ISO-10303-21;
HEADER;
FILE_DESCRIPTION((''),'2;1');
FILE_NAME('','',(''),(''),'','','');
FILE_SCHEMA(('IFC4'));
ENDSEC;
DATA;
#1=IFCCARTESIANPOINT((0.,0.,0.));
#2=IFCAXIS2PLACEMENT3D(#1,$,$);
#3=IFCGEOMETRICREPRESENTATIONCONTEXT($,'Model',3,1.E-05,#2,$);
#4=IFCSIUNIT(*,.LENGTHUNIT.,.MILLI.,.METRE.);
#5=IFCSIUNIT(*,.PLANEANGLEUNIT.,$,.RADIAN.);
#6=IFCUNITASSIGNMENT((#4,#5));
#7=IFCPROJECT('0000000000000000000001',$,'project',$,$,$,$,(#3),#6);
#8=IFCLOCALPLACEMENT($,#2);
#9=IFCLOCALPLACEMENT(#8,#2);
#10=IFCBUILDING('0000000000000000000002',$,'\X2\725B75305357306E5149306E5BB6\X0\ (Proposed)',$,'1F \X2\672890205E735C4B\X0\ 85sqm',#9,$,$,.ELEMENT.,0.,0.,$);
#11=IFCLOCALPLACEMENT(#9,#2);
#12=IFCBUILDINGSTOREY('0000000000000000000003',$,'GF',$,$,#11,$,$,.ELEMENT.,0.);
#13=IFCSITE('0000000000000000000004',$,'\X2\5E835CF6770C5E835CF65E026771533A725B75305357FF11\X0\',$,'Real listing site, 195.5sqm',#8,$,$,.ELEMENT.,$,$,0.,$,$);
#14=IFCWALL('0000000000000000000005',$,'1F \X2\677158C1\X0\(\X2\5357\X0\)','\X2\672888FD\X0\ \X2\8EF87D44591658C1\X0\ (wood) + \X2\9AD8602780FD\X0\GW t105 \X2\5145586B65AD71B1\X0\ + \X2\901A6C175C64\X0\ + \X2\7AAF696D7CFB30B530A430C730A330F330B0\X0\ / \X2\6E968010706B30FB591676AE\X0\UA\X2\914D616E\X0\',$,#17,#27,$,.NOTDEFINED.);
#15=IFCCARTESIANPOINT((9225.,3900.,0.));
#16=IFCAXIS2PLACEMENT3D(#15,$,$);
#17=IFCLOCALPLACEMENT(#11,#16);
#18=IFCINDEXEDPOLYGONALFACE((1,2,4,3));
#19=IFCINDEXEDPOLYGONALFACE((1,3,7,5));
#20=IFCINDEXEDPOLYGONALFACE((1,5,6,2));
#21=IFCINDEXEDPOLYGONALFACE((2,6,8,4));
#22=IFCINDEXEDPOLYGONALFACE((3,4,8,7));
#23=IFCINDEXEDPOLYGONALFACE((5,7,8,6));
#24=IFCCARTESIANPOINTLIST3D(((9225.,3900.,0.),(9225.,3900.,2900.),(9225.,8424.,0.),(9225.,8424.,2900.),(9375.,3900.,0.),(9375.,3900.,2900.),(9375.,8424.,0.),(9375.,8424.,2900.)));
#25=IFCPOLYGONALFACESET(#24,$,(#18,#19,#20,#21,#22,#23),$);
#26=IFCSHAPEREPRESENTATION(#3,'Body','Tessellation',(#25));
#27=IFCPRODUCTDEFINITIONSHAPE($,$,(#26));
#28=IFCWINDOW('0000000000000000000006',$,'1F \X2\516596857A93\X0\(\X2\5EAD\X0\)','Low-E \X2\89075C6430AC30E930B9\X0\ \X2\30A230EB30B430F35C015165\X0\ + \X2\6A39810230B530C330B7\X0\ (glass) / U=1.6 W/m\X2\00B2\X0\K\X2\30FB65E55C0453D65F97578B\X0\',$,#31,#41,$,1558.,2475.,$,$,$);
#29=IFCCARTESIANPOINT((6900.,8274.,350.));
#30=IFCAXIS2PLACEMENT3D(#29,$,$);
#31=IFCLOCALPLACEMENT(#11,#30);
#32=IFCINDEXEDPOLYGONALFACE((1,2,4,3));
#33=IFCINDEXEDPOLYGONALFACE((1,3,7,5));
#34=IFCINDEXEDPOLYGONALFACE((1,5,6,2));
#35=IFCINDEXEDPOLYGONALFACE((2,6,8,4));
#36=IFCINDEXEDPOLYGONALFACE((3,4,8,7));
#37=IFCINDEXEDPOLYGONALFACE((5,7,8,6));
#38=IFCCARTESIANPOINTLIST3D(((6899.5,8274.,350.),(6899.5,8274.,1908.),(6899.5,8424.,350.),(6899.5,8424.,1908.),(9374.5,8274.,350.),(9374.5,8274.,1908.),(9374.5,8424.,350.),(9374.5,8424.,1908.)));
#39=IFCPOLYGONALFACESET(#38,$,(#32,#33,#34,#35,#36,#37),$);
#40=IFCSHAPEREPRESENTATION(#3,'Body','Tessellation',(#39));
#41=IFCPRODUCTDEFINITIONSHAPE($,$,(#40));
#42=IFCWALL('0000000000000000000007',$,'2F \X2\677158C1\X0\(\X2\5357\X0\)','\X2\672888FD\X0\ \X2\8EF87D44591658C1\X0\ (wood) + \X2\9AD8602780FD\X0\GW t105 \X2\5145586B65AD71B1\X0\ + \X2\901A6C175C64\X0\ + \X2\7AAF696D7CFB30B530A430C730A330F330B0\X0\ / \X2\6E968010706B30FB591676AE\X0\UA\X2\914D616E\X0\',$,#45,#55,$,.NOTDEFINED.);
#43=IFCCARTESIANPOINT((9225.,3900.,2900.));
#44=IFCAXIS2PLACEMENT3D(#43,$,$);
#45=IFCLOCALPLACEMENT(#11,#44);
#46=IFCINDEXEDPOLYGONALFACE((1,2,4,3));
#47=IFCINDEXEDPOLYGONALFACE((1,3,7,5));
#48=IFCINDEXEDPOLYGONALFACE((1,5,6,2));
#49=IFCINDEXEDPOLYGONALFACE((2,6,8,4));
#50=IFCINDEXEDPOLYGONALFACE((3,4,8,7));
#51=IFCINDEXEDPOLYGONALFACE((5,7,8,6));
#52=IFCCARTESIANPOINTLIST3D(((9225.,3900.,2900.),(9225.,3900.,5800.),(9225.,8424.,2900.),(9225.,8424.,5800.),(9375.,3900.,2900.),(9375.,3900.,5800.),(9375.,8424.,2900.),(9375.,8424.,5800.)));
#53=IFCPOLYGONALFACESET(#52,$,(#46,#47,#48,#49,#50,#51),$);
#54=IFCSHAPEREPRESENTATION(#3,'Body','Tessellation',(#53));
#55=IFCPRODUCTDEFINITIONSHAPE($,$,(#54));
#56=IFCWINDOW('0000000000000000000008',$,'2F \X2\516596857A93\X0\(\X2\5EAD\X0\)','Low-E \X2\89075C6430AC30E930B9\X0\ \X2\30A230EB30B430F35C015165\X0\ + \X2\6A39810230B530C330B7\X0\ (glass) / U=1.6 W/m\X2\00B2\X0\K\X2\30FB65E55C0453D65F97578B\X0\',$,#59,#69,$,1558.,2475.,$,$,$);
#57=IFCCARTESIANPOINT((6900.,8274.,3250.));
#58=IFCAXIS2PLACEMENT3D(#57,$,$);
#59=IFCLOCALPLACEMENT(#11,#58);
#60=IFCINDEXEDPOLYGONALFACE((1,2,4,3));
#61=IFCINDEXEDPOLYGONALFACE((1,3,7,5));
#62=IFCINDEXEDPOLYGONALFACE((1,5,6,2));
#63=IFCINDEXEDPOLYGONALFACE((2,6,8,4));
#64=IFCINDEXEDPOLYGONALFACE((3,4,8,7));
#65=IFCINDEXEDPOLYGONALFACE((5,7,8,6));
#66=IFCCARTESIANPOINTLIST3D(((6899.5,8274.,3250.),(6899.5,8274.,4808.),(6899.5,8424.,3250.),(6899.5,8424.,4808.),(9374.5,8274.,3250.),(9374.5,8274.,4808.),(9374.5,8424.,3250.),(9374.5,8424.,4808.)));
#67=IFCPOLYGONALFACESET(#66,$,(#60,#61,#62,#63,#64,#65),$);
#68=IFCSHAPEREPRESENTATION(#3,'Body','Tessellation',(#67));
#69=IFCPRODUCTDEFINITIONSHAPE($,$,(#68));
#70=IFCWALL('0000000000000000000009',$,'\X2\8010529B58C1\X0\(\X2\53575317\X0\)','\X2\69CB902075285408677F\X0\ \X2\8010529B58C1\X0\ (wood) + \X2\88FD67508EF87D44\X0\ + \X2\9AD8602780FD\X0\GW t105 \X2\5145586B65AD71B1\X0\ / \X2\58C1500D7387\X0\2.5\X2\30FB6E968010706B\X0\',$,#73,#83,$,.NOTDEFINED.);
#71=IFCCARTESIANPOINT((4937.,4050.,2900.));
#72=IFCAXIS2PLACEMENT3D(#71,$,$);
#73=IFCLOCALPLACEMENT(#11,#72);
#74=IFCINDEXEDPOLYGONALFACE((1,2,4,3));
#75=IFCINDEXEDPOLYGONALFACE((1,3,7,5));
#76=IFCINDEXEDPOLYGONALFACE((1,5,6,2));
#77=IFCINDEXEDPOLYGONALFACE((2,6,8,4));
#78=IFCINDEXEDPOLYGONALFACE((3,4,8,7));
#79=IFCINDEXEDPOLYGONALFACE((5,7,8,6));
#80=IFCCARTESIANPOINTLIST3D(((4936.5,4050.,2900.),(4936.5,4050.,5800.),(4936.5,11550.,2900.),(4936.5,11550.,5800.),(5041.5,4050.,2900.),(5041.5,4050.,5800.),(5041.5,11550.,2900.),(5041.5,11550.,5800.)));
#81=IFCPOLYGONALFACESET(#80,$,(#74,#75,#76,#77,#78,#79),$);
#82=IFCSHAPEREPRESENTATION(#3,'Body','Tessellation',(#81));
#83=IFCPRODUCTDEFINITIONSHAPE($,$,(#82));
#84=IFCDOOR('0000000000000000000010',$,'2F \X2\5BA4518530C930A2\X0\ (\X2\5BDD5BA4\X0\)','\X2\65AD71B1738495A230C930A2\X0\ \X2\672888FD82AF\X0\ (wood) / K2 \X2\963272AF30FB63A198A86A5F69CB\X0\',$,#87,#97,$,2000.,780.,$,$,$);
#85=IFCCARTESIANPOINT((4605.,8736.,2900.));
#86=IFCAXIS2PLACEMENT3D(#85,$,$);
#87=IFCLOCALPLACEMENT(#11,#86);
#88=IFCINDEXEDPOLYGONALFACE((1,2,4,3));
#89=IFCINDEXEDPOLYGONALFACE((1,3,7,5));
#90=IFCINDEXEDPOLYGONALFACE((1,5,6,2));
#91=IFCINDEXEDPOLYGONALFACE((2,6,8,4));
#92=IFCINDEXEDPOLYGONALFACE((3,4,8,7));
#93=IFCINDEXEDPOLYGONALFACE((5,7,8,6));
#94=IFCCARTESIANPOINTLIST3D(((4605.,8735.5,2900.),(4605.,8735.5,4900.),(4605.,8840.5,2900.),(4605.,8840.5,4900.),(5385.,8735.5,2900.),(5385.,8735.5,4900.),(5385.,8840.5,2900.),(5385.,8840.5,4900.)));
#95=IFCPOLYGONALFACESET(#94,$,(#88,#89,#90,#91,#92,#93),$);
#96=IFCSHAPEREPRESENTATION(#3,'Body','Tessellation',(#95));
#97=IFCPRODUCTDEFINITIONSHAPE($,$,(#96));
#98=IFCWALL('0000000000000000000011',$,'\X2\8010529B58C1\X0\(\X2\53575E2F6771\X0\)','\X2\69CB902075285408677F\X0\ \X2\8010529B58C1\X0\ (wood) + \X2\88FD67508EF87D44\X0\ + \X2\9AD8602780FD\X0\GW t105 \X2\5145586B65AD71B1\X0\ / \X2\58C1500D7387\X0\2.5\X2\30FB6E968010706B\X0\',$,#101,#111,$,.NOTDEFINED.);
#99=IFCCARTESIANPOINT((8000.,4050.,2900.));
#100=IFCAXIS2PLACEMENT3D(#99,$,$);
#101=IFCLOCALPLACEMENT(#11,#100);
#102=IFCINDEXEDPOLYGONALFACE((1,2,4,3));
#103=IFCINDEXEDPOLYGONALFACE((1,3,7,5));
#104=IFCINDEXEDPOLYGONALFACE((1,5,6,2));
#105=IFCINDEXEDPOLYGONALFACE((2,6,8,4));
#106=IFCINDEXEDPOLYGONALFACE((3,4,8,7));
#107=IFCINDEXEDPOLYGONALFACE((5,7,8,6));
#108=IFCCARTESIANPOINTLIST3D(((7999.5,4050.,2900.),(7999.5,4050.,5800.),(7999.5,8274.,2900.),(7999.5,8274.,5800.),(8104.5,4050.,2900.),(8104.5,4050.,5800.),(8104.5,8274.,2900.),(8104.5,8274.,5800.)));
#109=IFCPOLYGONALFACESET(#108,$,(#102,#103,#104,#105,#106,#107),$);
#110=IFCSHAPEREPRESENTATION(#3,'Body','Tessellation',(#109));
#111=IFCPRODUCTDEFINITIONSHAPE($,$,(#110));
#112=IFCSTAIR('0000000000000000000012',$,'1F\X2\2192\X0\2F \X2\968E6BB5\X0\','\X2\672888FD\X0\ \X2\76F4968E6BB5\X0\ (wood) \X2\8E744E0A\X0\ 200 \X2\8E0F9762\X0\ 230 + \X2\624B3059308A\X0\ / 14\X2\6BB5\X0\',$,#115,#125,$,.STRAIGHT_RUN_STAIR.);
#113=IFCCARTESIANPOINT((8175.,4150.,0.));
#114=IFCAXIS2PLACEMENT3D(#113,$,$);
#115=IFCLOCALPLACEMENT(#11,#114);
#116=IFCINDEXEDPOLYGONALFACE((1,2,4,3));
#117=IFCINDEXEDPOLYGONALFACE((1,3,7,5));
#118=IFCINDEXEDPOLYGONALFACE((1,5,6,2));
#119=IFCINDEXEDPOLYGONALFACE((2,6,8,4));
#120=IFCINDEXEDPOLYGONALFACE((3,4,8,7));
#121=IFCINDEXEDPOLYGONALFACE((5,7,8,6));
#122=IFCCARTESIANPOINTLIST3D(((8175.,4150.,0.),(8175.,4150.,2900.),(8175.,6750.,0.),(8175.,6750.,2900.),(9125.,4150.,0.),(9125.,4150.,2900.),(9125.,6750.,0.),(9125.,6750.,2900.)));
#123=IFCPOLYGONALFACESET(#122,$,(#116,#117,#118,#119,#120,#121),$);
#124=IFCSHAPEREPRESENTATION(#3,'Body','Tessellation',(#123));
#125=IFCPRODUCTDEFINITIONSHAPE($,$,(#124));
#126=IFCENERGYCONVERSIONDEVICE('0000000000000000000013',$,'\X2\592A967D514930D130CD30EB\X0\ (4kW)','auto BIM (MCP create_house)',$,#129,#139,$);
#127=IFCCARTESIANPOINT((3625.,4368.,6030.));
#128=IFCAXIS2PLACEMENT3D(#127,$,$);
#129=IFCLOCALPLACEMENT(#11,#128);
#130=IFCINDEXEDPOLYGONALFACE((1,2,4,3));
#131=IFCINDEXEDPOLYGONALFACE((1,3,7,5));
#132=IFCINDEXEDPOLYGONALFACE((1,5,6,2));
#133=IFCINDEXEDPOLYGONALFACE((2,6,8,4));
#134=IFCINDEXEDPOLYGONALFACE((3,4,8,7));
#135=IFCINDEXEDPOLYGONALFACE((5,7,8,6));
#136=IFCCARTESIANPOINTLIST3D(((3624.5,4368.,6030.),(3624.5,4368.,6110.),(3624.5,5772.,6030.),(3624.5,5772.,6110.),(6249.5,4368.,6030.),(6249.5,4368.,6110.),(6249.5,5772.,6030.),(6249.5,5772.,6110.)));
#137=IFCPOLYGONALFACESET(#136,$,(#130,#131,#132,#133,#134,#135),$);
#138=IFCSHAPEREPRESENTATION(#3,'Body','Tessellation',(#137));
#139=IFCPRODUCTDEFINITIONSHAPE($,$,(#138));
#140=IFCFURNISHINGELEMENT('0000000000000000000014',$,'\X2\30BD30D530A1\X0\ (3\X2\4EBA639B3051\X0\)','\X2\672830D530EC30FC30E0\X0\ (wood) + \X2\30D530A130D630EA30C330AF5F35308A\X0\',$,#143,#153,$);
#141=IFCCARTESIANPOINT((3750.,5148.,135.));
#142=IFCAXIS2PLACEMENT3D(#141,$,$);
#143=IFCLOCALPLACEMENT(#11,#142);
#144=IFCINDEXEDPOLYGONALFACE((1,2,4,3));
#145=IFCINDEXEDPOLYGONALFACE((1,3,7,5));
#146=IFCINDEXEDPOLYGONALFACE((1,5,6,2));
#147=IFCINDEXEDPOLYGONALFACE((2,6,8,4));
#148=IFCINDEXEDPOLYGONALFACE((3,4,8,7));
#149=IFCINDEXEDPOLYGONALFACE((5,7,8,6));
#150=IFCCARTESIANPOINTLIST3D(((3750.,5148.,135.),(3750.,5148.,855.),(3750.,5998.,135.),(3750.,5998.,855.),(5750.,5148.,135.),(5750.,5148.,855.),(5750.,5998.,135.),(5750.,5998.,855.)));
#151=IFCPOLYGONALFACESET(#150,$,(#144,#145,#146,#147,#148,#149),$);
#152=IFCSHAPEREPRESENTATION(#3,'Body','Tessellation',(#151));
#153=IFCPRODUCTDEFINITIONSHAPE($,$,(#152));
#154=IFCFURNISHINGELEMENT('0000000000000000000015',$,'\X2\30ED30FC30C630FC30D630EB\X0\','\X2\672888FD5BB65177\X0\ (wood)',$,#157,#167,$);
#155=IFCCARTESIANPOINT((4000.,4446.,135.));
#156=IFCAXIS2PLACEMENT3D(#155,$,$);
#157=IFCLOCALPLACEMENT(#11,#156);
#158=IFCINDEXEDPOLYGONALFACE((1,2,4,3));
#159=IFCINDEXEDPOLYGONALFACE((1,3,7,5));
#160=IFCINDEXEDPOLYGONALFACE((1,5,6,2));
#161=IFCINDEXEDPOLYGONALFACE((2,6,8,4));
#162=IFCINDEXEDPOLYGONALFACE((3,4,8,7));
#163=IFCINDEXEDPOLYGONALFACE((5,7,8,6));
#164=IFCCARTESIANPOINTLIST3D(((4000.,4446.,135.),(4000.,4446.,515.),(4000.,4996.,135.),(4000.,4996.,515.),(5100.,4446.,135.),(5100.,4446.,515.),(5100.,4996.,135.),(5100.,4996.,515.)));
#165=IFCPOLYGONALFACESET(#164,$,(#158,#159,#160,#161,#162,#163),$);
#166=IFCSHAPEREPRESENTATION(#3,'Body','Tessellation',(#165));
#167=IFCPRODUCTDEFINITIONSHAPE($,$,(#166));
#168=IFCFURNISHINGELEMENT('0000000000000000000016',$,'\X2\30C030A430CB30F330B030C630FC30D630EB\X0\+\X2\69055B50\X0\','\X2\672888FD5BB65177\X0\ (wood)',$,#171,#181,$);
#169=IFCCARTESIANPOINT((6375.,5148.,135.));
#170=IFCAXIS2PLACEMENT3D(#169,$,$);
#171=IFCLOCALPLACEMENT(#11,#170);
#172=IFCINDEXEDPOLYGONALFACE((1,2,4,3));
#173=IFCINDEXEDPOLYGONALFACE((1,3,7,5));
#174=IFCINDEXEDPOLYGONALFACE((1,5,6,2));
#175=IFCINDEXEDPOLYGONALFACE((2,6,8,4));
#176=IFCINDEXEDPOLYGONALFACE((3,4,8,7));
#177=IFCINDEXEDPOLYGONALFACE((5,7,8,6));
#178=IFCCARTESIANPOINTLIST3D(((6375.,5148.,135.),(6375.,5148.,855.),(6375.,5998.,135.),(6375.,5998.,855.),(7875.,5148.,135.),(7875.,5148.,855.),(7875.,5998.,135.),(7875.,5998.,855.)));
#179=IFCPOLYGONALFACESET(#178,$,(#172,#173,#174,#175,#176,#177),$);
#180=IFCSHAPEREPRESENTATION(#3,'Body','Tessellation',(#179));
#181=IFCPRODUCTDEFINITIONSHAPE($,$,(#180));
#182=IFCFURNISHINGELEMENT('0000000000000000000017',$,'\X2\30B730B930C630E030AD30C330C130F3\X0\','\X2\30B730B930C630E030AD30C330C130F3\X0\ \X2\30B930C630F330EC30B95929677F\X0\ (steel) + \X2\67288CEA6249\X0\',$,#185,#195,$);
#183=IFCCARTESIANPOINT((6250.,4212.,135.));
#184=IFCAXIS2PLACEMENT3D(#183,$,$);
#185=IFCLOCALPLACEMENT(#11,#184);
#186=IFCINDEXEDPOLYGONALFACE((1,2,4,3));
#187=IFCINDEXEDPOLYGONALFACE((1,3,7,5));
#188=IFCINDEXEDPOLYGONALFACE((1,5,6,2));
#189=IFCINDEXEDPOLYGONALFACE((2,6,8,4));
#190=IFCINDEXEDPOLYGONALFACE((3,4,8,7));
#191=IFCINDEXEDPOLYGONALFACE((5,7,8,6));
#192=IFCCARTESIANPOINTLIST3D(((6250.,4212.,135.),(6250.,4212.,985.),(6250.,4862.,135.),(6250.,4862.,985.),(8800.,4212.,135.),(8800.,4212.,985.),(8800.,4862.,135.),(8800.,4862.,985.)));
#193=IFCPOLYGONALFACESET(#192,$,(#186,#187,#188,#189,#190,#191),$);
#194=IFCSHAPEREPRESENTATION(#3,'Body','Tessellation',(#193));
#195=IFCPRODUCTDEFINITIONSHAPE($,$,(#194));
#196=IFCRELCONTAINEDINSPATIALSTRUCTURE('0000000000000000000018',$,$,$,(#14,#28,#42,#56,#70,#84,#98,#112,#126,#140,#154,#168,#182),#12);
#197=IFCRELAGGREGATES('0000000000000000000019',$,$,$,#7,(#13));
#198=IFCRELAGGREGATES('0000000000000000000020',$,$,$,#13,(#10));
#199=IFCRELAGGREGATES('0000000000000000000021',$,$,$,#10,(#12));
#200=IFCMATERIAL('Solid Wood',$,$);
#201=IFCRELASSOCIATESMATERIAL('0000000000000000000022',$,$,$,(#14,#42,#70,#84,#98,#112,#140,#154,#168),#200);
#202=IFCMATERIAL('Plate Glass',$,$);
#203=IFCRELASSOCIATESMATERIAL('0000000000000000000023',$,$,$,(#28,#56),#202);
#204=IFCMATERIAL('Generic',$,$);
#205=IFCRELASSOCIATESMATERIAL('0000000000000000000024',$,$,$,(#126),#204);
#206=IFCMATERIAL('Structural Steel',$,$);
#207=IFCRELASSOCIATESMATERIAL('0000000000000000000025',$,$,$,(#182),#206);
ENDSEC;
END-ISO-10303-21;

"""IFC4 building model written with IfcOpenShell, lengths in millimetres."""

from ifc_helpers import new_model, si_unit, frame, frame_2d, origin, place, context, project, spatial, rectangle, extrude, material, element, fill, save


model = new_model("IFC4")

# Units and contexts
model_context = context("Model", 3, precision=1e-05, world=origin())
ifc_project = project(units=[si_unit("LENGTHUNIT", "METRE", prefix="MILLI"), si_unit("PLANEANGLEUNIT", "RADIAN")], contexts=[model_context])

# Site, building, storey
site_placement = place(None, origin())
site = spatial("IfcSite", under=ifc_project, at=site_placement, Name="広島県広島市東区牛田南１", ObjectType="Real listing site, 195.5sqm", CompositionType="ELEMENT", RefElevation=0.0)
building_placement = place(site_placement, origin())
building = spatial("IfcBuilding", under=site, at=building_placement, Name="牛田南の光の家 (Proposed)", ObjectType="1F 木造平屋 85sqm", CompositionType="ELEMENT", ElevationOfRefHeight=0.0, ElevationOfTerrain=0.0)
storey_placement = place(building_placement, origin())
storey = spatial("IfcBuildingStorey", under=building, at=storey_placement, Name="GF", CompositionType="ELEMENT", Elevation=0.0)

# Wall, opening, window
ifc_material_1 = material(Name="Solid Wood")
wall_1_placement = place(storey_placement, frame((9225.0, 3900.0, 0.0)))
wall_1 = element("IfcWall", 1, at=wall_1_placement, inside=storey, material=ifc_material_1, Name="1F 東壁(南)", Description="木製 軸組外壁 (wood) + 高性能GW t105 充填断熱 + 通気層 + 窯業系サイディング / 準耐火・外皮UA配慮", PredefinedType="NOTDEFINED", context=model_context, shape_type="SweptSolid", body=[
    extrude(rectangle(XDim=150.0, YDim=4524.0, at=frame_2d((75.0, 2262.0))), frame((9225.0, 3900.0, 0.0)), (0.0, 0.0, 1.0), 2900.0),
])
opening_1_placement = place(storey_placement, frame((6900.0, 8274.0, 350.0)))
opening_1 = element("IfcOpeningElement", 2, at=opening_1_placement, cuts=wall_1, PredefinedType="NOTDEFINED", context=model_context, shape_type="SweptSolid", body=[
    extrude(rectangle(XDim=2475.0, YDim=150.0, at=frame_2d((1237.0, 75.0))), frame((6900.0, 8274.0, 350.0)), (0.0, 0.0, 1.0), 1558.0),
])
ifc_material_2 = material(Name="Plate Glass")
window_1_placement = place(storey_placement, frame((6900.0, 8274.0, 350.0)))
window_1 = element("IfcWindow", 3, at=window_1_placement, inside=storey, material=ifc_material_2, Name="1F 入隅窓(庭)", Description="Low-E 複層ガラス アルゴン封入 + 樹脂サッシ (glass) / U=1.6 W/m²K・日射取得型", OverallHeight=1558.0, OverallWidth=2475.0, context=model_context, shape_type="SweptSolid", body=[
    extrude(rectangle(XDim=2475.0, YDim=150.0, at=frame_2d((1237.0, 75.0))), frame((6900.0, 8274.0, 350.0)), (0.0, 0.0, 1.0), 1558.0),
])
fill(opening_1, window_1)

# Wall, opening, window
wall_2_placement = place(storey_placement, frame((9225.0, 3900.0, 2900.0)))
wall_2 = element("IfcWall", 4, at=wall_2_placement, inside=storey, material=ifc_material_1, Name="2F 東壁(南)", Description="木製 軸組外壁 (wood) + 高性能GW t105 充填断熱 + 通気層 + 窯業系サイディング / 準耐火・外皮UA配慮", PredefinedType="NOTDEFINED", context=model_context, shape_type="SweptSolid", body=[
    extrude(rectangle(XDim=150.0, YDim=4524.0, at=frame_2d((75.0, 2262.0))), frame((9225.0, 3900.0, 2900.0)), (0.0, 0.0, 1.0), 2900.0),
])
opening_2_placement = place(storey_placement, frame((6900.0, 8274.0, 3250.0)))
opening_2 = element("IfcOpeningElement", 5, at=opening_2_placement, cuts=wall_2, PredefinedType="NOTDEFINED", context=model_context, shape_type="SweptSolid", body=[
    extrude(rectangle(XDim=2475.0, YDim=150.0, at=frame_2d((1237.0, 75.0))), frame((6900.0, 8274.0, 3250.0)), (0.0, 0.0, 1.0), 1558.0),
])
window_2_placement = place(storey_placement, frame((6900.0, 8274.0, 3250.0)))
window_2 = element("IfcWindow", 6, at=window_2_placement, inside=storey, material=ifc_material_2, Name="2F 入隅窓(庭)", Description="Low-E 複層ガラス アルゴン封入 + 樹脂サッシ (glass) / U=1.6 W/m²K・日射取得型", OverallHeight=1558.0, OverallWidth=2475.0, context=model_context, shape_type="SweptSolid", body=[
    extrude(rectangle(XDim=2475.0, YDim=150.0, at=frame_2d((1237.0, 75.0))), frame((6900.0, 8274.0, 3250.0)), (0.0, 0.0, 1.0), 1558.0),
])
fill(opening_2, window_2)

# Wall, opening, door
wall_3_placement = place(storey_placement, frame((4937.0, 4050.0, 2900.0)))
wall_3 = element("IfcWall", 7, at=wall_3_placement, inside=storey, material=ifc_material_1, Name="耐力壁(南北)", Description="構造用合板 耐力壁 (wood) + 製材軸組 + 高性能GW t105 充填断熱 / 壁倍率2.5・準耐火", PredefinedType="NOTDEFINED", context=model_context, shape_type="SweptSolid", body=[
    extrude(rectangle(XDim=105.0, YDim=7500.0, at=frame_2d((52.0, 3750.0))), frame((4937.0, 4050.0, 2900.0)), (0.0, 0.0, 1.0), 2900.0),
])
opening_3_placement = place(storey_placement, frame((4605.0, 8736.0, 2900.0)))
opening_3 = element("IfcOpeningElement", 8, at=opening_3_placement, cuts=wall_3, PredefinedType="NOTDEFINED", context=model_context, shape_type="SweptSolid", body=[
    extrude(rectangle(XDim=780.0, YDim=105.0, at=frame_2d((390.0, 52.0))), frame((4605.0, 8736.0, 2900.0)), (0.0, 0.0, 1.0), 2000.0),
])
door_1_placement = place(storey_placement, frame((4605.0, 8736.0, 2900.0)))
door_1 = element("IfcDoor", 9, at=door_1_placement, inside=storey, material=ifc_material_1, Name="2F 室内ドア (寝室)", Description="断熱玄関ドア 木製芯 (wood) / K2 防犯・採風機構", OverallHeight=2000.0, OverallWidth=780.0, context=model_context, shape_type="SweptSolid", body=[
    extrude(rectangle(XDim=780.0, YDim=105.0, at=frame_2d((390.0, 52.0))), frame((4605.0, 8736.0, 2900.0)), (0.0, 0.0, 1.0), 2000.0),
])
fill(opening_3, door_1)

# Wall
wall_4_placement = place(storey_placement, frame((8000.0, 4050.0, 2900.0)))
element("IfcWall", 10, at=wall_4_placement, inside=storey, material=ifc_material_1, Name="耐力壁(南帯東)", Description="構造用合板 耐力壁 (wood) + 製材軸組 + 高性能GW t105 充填断熱 / 壁倍率2.5・準耐火", PredefinedType="NOTDEFINED", context=model_context, shape_type="SweptSolid", body=[
    extrude(rectangle(XDim=105.0, YDim=4224.0, at=frame_2d((52.0, 2112.0))), frame((8000.0, 4050.0, 2900.0)), (0.0, 0.0, 1.0), 2900.0),
])

# Stair
stair_placement = place(storey_placement, frame((8175.0, 4150.0, 0.0)))
element("IfcStair", 11, at=stair_placement, inside=storey, material=ifc_material_1, Name="1F→2F 階段", Description="木製 直階段 (wood) 蹴上 200 踏面 230 + 手すり / 14段", PredefinedType="STRAIGHT_RUN_STAIR", context=model_context, shape_type="SweptSolid", body=[
    extrude(rectangle(XDim=950.0, YDim=2600.0, at=frame_2d((475.0, 1300.0))), frame((8175.0, 4150.0, 0.0)), (0.0, 0.0, 1.0), 2900.0),
])

# Energy conversion device
ifc_material_3 = material(Name="Generic")
energy_conversion_device_placement = place(storey_placement, frame((3625.0, 4368.0, 6030.0)))
element("IfcEnergyConversionDevice", 12, at=energy_conversion_device_placement, inside=storey, material=ifc_material_3, Name="太陽光パネル (4kW)", Description="auto BIM (MCP create_house)", context=model_context, shape_type="SweptSolid", body=[
    extrude(rectangle(XDim=2625.0, YDim=1404.0, at=frame_2d((1312.0, 702.0))), frame((3625.0, 4368.0, 6030.0)), (0.0, 0.0, 1.0), 80.0),
])

# Furnishing elements
furnishing_1_placement = place(storey_placement, frame((3750.0, 5148.0, 135.0)))
element("IfcFurnishingElement", 13, at=furnishing_1_placement, inside=storey, material=ifc_material_1, Name="ソファ (3人掛け)", Description="木フレーム (wood) + ファブリック張り", context=model_context, shape_type="SweptSolid", body=[
    extrude(rectangle(XDim=2000.0, YDim=850.0, at=frame_2d((1000.0, 425.0))), frame((3750.0, 5148.0, 135.0)), (0.0, 0.0, 1.0), 720.0),
])
furnishing_2_placement = place(storey_placement, frame((4000.0, 4446.0, 135.0)))
element("IfcFurnishingElement", 14, at=furnishing_2_placement, inside=storey, material=ifc_material_1, Name="ローテーブル", Description="木製家具 (wood)", context=model_context, shape_type="SweptSolid", body=[
    extrude(rectangle(XDim=1100.0, YDim=550.0, at=frame_2d((550.0, 275.0))), frame((4000.0, 4446.0, 135.0)), (0.0, 0.0, 1.0), 380.0),
])
furnishing_3_placement = place(storey_placement, frame((6375.0, 5148.0, 135.0)))
element("IfcFurnishingElement", 15, at=furnishing_3_placement, inside=storey, material=ifc_material_1, Name="ダイニングテーブル+椅子", Description="木製家具 (wood)", context=model_context, shape_type="SweptSolid", body=[
    extrude(rectangle(XDim=1500.0, YDim=850.0, at=frame_2d((750.0, 425.0))), frame((6375.0, 5148.0, 135.0)), (0.0, 0.0, 1.0), 720.0),
])
ifc_material_4 = material(Name="Structural Steel")
furnishing_4_placement = place(storey_placement, frame((6250.0, 4212.0, 135.0)))
element("IfcFurnishingElement", 16, at=furnishing_4_placement, inside=storey, material=ifc_material_4, Name="システムキッチン", Description="システムキッチン ステンレス天板 (steel) + 木質扉", context=model_context, shape_type="SweptSolid", body=[
    extrude(rectangle(XDim=2550.0, YDim=650.0, at=frame_2d((1275.0, 325.0))), frame((6250.0, 4212.0, 135.0)), (0.0, 0.0, 1.0), 850.0),
])

save(model, "model.ifc")
